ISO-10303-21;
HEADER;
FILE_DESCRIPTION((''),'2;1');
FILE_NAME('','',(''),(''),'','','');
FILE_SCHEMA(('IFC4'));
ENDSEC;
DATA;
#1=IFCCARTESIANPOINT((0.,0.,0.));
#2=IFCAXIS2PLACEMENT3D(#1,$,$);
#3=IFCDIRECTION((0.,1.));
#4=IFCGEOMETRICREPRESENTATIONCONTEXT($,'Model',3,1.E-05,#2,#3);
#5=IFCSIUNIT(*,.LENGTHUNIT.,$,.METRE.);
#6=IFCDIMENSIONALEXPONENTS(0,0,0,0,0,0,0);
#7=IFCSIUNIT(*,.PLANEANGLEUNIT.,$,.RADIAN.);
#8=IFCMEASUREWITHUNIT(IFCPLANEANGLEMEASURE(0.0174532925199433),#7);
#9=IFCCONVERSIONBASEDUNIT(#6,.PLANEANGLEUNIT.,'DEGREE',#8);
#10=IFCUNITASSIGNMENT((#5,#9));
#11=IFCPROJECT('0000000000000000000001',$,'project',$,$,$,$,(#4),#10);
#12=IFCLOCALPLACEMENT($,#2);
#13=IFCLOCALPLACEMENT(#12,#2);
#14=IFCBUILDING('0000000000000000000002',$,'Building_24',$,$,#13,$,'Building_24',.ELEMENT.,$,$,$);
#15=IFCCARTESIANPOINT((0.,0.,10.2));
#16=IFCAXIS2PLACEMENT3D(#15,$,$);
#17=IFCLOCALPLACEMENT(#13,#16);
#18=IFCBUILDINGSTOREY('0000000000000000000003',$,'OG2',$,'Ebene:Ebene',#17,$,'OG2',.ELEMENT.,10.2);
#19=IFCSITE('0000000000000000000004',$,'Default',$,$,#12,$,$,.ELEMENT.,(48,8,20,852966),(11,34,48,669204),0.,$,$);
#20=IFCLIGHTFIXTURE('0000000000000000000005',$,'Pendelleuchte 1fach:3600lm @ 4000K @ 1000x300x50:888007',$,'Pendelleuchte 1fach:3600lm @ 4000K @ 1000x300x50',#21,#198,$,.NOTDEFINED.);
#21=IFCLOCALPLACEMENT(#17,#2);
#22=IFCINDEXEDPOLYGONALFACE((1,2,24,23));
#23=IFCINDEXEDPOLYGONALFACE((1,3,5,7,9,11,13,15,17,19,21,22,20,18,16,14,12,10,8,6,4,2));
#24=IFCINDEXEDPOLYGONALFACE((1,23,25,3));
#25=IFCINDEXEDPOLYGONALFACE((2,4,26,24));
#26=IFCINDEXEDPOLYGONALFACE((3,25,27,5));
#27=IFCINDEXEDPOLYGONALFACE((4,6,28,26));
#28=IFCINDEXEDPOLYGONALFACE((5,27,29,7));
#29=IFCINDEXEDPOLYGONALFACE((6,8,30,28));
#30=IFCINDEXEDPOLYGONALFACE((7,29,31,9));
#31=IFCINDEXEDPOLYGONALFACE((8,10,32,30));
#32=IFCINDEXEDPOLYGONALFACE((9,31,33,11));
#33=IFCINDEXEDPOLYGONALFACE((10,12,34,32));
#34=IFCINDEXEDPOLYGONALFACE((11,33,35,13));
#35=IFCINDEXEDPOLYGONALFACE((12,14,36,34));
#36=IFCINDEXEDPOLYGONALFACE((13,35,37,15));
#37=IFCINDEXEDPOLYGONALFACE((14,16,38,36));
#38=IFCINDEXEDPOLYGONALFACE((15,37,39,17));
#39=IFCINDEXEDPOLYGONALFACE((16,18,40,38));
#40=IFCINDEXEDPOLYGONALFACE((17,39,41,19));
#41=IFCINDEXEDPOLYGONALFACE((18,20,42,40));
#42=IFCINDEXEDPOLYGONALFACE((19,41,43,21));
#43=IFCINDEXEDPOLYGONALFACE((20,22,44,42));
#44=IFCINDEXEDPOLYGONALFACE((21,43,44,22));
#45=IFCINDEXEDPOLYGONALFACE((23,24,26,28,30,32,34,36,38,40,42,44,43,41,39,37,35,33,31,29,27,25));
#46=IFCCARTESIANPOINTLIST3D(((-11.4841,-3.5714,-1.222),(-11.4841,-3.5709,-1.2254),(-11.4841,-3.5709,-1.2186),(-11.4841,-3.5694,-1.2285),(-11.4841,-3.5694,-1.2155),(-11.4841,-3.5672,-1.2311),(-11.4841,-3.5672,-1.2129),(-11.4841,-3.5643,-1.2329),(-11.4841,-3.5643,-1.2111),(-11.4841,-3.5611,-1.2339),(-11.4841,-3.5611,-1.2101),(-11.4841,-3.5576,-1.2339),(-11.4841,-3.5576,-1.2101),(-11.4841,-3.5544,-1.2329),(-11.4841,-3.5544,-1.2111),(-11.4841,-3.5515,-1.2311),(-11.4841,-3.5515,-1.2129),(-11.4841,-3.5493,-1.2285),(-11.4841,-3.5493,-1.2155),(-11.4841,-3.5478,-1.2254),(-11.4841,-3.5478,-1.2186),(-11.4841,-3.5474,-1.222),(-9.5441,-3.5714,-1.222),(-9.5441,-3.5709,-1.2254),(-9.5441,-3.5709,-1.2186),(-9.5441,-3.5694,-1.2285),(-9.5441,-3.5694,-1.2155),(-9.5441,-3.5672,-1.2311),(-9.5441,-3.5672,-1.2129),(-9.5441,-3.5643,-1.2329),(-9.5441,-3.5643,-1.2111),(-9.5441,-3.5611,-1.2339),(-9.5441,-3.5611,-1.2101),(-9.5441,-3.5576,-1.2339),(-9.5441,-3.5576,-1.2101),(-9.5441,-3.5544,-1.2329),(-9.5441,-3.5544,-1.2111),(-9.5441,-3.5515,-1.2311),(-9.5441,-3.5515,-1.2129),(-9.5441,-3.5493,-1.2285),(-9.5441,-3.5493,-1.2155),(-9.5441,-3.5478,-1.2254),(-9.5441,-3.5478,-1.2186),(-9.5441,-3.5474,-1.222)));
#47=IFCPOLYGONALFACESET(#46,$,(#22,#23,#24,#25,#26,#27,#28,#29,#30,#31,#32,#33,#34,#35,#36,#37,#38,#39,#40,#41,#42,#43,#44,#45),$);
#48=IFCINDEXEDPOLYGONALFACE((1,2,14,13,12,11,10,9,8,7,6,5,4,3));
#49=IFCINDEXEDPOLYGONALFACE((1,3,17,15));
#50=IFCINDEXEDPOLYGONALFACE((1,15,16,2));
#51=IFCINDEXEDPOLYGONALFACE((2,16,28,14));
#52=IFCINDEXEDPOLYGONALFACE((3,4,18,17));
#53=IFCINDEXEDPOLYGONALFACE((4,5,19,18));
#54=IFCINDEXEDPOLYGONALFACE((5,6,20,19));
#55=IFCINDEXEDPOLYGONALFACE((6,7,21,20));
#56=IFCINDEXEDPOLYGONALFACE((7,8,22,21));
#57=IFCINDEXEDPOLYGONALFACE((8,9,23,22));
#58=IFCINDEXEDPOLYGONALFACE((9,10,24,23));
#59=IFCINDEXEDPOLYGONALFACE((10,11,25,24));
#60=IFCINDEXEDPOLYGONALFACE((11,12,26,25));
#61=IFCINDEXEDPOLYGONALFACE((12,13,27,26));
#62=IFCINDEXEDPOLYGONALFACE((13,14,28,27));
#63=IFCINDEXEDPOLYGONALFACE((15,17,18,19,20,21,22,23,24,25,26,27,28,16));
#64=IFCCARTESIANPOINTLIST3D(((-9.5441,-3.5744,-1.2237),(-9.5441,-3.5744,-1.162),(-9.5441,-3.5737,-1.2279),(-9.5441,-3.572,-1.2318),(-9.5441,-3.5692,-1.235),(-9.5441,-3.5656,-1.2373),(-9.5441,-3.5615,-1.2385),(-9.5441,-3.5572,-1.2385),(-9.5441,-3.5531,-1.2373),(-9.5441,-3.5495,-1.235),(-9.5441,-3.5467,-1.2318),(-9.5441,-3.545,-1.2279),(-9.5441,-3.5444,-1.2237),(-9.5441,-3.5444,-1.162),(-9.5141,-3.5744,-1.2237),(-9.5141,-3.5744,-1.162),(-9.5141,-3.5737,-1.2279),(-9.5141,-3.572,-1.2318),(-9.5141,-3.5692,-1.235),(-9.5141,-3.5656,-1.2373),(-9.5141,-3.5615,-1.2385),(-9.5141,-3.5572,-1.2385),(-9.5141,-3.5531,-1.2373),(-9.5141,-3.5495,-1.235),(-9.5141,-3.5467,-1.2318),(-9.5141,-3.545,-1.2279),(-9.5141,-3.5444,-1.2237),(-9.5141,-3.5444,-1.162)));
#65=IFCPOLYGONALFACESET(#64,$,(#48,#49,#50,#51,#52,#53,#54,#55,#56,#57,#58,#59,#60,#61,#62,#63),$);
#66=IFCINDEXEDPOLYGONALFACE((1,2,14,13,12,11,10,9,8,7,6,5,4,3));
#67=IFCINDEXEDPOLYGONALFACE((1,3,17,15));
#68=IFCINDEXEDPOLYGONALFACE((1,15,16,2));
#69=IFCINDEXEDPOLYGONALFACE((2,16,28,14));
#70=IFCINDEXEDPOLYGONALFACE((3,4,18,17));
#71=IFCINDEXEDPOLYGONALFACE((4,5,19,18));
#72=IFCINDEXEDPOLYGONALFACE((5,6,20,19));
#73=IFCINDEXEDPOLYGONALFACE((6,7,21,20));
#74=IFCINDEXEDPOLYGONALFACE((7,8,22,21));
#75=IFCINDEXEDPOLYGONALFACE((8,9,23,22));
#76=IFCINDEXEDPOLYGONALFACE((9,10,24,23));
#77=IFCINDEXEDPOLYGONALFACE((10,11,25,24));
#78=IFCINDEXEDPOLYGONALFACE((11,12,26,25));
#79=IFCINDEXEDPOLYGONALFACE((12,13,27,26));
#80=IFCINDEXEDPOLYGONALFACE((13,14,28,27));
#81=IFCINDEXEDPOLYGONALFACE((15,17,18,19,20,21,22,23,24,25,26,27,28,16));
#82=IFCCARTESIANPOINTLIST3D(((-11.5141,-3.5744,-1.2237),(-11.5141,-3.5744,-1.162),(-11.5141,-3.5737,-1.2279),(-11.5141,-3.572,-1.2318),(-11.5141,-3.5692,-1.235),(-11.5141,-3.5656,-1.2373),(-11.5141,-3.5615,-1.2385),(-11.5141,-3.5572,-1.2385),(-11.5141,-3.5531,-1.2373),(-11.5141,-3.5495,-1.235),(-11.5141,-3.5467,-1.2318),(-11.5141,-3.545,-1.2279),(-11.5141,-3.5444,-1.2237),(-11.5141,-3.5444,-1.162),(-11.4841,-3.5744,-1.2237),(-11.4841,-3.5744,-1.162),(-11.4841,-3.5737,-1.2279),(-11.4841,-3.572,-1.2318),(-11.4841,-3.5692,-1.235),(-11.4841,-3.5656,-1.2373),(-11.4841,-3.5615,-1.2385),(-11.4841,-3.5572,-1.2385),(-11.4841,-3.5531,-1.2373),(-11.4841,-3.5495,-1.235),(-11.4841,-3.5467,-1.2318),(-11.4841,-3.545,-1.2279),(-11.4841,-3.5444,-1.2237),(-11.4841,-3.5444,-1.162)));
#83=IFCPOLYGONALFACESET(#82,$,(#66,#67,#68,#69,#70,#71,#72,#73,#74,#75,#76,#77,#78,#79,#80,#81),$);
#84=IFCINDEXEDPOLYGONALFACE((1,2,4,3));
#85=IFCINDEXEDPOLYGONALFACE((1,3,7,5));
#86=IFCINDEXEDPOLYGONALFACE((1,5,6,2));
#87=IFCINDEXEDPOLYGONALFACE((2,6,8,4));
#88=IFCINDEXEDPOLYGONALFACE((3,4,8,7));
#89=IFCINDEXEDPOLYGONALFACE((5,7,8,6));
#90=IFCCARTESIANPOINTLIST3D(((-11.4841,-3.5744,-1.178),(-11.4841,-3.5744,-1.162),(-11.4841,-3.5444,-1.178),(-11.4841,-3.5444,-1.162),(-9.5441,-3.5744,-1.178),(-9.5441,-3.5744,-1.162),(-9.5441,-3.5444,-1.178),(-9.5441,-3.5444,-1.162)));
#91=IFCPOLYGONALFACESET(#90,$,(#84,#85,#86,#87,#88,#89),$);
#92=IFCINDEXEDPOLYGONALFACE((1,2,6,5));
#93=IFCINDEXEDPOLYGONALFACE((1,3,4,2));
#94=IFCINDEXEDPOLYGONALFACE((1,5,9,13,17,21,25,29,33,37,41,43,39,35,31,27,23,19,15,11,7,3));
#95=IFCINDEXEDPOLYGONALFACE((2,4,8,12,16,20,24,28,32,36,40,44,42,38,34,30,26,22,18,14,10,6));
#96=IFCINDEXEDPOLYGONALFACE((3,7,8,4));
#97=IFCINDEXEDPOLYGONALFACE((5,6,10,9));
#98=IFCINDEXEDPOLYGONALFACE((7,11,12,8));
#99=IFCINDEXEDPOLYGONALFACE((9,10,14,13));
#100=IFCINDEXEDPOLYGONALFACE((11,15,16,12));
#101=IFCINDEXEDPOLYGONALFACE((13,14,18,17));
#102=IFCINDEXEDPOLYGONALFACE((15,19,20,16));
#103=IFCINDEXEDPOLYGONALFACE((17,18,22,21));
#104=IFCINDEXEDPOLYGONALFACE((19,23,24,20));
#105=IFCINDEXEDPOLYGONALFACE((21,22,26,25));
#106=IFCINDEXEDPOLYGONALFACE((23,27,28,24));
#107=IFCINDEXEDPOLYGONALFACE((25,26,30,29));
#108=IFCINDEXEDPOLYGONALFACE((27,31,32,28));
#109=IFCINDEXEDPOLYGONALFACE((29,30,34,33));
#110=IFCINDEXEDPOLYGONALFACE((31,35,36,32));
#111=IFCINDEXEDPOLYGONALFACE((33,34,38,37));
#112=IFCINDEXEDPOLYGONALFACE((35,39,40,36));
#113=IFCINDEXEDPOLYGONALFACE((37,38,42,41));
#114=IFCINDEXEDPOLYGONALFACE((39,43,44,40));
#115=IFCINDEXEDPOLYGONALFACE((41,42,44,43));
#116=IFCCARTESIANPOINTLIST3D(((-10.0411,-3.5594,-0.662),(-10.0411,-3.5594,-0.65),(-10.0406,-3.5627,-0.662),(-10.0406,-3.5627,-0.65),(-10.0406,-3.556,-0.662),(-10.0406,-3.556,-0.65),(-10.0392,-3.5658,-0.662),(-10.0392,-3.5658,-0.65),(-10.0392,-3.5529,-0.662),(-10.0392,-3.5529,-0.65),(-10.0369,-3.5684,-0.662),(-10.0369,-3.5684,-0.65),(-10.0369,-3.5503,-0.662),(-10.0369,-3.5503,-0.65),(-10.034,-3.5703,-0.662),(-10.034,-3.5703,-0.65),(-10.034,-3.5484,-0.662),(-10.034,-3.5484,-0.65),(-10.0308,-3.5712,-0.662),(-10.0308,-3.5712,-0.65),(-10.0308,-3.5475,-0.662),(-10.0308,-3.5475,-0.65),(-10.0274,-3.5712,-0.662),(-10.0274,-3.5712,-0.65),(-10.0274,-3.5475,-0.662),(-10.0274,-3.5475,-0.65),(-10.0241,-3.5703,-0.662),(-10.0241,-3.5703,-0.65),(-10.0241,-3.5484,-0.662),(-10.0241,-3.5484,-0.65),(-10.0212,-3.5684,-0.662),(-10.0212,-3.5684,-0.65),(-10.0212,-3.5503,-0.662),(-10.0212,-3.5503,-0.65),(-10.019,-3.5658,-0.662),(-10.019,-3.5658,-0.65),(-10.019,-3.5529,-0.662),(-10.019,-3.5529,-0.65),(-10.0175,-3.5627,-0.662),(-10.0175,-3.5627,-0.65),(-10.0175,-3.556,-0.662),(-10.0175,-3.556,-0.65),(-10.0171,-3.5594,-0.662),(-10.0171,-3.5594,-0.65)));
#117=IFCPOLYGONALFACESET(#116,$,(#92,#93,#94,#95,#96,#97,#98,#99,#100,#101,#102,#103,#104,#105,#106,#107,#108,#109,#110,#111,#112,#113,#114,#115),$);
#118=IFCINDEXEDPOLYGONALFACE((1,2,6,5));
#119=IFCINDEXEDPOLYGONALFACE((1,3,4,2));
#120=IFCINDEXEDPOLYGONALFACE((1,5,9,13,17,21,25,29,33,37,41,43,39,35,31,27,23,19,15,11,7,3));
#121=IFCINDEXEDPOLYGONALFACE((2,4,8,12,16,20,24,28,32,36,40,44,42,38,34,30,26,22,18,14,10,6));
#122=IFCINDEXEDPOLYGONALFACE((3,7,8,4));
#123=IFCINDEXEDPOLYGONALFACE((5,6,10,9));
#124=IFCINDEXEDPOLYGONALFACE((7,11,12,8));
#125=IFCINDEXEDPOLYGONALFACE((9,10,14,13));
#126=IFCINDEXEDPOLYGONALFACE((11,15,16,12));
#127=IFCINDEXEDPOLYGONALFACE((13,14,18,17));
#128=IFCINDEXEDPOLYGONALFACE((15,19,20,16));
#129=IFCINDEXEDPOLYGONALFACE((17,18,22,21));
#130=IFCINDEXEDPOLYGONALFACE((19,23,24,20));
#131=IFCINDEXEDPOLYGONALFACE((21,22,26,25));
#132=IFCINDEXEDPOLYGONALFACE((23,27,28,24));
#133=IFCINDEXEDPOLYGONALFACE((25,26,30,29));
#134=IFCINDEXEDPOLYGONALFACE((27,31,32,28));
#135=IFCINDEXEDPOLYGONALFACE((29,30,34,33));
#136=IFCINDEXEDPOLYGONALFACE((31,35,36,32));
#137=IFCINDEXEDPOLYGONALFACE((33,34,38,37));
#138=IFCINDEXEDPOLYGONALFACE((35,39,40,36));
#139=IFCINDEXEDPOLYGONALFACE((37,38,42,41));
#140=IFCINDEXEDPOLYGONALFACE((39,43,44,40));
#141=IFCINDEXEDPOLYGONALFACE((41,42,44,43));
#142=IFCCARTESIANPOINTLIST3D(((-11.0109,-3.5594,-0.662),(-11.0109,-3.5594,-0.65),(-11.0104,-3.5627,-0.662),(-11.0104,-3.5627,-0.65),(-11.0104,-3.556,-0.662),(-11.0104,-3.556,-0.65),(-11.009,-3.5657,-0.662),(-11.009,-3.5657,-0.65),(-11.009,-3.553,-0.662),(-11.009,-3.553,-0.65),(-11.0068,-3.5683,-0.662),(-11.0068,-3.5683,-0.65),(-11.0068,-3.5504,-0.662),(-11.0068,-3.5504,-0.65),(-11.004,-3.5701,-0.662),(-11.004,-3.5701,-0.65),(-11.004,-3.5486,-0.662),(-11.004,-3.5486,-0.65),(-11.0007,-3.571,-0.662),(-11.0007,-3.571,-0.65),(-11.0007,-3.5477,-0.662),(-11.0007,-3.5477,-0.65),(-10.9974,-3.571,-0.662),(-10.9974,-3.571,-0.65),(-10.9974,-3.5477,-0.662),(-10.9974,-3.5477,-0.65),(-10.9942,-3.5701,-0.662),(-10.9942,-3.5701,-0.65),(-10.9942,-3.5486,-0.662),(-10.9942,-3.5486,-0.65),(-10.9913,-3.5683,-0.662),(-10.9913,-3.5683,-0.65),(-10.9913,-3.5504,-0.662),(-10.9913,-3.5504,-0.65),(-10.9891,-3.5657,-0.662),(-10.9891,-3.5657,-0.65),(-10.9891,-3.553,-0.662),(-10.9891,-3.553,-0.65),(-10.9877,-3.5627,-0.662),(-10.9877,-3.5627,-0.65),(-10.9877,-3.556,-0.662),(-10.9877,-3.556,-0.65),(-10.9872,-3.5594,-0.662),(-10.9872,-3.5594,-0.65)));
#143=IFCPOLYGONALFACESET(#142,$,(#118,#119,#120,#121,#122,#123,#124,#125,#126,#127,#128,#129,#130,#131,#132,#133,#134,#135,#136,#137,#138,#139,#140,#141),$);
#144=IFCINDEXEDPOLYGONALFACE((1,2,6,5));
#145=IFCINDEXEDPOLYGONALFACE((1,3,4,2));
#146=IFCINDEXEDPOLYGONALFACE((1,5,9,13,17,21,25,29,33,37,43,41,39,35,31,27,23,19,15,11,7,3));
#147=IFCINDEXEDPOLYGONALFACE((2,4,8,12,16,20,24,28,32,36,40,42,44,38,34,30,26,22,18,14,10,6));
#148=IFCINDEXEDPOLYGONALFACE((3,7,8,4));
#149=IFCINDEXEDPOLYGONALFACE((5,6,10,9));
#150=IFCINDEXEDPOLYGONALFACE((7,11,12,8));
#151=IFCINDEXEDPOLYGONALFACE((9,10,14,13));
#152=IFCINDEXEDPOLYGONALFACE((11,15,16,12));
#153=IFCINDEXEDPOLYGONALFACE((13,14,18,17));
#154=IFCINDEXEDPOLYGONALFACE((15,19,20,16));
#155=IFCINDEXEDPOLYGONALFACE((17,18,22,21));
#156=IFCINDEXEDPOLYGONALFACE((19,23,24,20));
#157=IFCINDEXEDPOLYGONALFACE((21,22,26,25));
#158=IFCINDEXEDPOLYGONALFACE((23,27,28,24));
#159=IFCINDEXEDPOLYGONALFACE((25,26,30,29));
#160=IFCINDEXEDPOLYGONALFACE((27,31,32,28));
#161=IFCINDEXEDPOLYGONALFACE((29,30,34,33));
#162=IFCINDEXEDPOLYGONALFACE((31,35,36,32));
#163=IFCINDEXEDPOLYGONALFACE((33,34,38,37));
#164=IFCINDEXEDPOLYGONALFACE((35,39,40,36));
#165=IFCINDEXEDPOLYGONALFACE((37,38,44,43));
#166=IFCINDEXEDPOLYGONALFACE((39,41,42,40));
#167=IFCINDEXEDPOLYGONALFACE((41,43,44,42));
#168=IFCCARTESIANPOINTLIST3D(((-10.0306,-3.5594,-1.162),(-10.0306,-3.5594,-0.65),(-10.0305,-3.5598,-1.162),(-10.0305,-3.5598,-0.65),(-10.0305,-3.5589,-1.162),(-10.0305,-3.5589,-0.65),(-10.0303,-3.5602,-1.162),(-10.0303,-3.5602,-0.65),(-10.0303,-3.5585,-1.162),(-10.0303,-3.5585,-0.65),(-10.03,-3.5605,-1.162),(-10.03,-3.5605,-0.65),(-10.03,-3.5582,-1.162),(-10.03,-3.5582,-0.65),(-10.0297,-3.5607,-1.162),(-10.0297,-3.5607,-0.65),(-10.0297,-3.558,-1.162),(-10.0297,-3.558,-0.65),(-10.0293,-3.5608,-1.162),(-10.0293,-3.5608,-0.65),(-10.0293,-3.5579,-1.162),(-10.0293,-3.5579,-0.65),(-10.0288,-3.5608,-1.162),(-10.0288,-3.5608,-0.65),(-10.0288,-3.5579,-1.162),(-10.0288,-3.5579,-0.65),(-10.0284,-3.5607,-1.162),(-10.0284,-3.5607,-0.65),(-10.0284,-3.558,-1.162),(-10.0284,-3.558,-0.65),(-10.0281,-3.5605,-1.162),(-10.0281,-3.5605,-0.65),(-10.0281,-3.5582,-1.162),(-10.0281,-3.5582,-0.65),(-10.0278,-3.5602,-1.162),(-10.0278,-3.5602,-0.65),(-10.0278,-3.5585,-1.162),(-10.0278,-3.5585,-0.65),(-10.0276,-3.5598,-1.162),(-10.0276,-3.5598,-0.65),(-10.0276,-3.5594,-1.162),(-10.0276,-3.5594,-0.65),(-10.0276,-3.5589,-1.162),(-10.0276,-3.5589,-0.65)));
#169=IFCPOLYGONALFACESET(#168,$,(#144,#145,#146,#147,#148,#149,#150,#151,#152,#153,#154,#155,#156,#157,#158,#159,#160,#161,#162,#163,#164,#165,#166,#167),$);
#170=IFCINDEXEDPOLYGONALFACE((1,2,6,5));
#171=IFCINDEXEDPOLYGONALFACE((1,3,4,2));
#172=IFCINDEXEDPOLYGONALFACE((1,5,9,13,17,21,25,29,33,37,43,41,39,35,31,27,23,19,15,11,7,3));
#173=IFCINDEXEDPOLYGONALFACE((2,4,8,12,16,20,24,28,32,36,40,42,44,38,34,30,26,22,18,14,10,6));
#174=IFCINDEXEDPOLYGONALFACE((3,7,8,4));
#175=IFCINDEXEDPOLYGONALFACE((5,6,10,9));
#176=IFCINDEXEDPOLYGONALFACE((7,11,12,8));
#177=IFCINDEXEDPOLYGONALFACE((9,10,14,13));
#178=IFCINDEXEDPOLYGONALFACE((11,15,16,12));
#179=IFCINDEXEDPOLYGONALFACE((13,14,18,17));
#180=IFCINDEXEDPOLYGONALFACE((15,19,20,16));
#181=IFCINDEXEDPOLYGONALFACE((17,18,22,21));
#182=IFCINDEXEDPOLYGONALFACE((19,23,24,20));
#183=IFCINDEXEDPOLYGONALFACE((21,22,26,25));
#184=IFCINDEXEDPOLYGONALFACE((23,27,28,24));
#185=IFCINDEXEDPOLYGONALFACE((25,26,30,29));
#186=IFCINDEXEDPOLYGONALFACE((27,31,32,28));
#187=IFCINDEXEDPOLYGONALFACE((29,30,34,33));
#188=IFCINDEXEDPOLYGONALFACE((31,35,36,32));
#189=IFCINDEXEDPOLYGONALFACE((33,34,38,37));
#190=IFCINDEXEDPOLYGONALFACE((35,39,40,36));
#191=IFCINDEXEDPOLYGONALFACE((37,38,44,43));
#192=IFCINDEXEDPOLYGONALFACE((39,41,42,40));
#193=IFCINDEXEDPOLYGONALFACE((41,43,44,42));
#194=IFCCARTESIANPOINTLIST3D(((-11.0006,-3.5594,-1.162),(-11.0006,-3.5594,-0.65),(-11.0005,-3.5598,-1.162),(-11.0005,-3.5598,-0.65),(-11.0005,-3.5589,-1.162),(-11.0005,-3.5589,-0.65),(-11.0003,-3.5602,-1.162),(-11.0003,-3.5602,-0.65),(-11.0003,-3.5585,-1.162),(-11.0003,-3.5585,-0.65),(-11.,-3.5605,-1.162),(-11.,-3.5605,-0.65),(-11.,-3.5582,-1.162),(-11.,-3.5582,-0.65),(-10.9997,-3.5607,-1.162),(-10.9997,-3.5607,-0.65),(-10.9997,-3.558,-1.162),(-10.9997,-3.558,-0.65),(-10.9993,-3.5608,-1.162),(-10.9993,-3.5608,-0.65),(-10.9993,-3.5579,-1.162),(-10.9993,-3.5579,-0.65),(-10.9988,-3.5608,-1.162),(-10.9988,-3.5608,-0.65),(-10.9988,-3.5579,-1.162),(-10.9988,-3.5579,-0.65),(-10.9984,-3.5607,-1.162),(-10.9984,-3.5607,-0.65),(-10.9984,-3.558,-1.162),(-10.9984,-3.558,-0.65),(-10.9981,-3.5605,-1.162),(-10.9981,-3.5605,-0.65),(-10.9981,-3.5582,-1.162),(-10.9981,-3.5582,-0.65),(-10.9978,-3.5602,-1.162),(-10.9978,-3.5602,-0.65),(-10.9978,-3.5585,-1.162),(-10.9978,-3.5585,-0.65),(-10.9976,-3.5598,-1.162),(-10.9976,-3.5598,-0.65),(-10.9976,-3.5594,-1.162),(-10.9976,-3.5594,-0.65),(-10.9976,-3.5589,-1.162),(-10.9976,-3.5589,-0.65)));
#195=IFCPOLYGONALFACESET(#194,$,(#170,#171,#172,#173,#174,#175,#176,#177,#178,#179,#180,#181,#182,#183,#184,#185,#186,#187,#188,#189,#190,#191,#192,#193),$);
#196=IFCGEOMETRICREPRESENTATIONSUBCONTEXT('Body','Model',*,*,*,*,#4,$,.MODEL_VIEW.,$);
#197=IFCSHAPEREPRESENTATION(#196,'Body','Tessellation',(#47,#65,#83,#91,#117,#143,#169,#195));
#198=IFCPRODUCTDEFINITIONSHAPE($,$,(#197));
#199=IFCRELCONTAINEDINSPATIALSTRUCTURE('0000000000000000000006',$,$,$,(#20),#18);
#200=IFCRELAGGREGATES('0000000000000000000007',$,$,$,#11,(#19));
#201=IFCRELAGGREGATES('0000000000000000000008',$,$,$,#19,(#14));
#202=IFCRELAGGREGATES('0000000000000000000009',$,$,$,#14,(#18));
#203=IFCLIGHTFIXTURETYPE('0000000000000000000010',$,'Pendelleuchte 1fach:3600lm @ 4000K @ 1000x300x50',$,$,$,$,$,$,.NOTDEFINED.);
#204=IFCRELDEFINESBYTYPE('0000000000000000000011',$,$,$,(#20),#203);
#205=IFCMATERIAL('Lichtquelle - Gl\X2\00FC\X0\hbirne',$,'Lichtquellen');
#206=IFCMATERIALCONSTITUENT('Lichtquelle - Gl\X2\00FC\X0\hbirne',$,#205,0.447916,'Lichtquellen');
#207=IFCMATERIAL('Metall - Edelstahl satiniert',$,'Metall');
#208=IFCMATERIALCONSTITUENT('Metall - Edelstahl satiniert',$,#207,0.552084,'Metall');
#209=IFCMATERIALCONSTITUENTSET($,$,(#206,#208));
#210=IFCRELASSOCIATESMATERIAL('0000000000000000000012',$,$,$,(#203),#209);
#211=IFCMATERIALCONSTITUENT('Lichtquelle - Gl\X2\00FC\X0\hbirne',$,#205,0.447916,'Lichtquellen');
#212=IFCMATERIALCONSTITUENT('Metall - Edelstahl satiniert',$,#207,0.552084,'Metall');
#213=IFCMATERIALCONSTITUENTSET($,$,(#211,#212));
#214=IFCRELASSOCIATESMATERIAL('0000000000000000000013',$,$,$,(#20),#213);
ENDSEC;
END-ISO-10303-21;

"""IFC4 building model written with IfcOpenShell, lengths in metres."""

from ifc_helpers import new_model, entity, si_unit, converted_unit, direction, frame, origin, place, context, subcontext, project, spatial, line, arc, indexed_curve, outline, extrude, source, transform, mapped, material, constituent, constituent_set, type_object, type_shapes, element, save


model = new_model("IFC4")

# Units and contexts
model_context = context("Model", 3, precision=1e-05, world=origin(), true_north=direction((0.0, 1.0)))
body_context = subcontext(model_context, "Body", "Model", "MODEL_VIEW")
ifc_project = project(units=[si_unit("LENGTHUNIT", "METRE"), converted_unit("PLANEANGLEUNIT", "DEGREE", entity("IfcPlaneAngleMeasure", 0.0174532925199433), si_unit("PLANEANGLEUNIT", "RADIAN"), dimensions=[0, 0, 0, 0, 0, 0, 0])], contexts=[model_context])

# Site, building, storey
site_placement = place(None, origin())
site = spatial("IfcSite", under=ifc_project, at=site_placement, Name="Default", CompositionType="ELEMENT", RefLatitude=(48, 8, 20, 852966), RefLongitude=(11, 34, 48, 669204), RefElevation=0.0)
building_placement = place(site_placement, origin())
building = spatial("IfcBuilding", under=site, at=building_placement, Name="Building_24", LongName="Building_24", CompositionType="ELEMENT")
storey_placement = place(building_placement, frame((0.0, 0.0, 10.2)))
storey = spatial("IfcBuildingStorey", under=building, at=storey_placement, Name="OG2", ObjectType="Ebene:Ebene", LongName="OG2", CompositionType="ELEMENT", Elevation=10.2)

# Light fixture
ifc_material_1 = material(Name="Lichtquelle - Glühbirne", Category="Lichtquellen")
ifc_material_2 = material(Name="Metall - Edelstahl satiniert", Category="Metall")
ifc_constituent_1 = constituent(ifc_material_1, Name="Lichtquelle - Glühbirne", Category="Lichtquellen", fraction=0.447916)
ifc_constituent_2 = constituent(ifc_material_2, Name="Metall - Edelstahl satiniert", Category="Metall", fraction=0.552084)
ifc_constituent_set_1 = constituent_set(constituents=[ifc_constituent_1, ifc_constituent_2])
light_fixture_type_1 = type_object("IfcLightFixtureType", Name="Pendelleuchte 1fach:3600lm @ 4000K @ 1000x300x50", PredefinedType="NOTDEFINED", material=ifc_constituent_set_1)
shared_shape_1 = source(origin(), body_context, "Body", "SweptSolid", [
    extrude(outline(indexed_curve([(-0.012, 0.0), (0.0, -0.012), (0.012, 0.0), (0.0, 0.012)], segments=[arc(1, 2, 3), arc(3, 4, 1)], self_intersect=False)), frame((-0.97, 0.0, -0.572), z_axis=(1.0, 0.0, 0.0), x_axis=(0.0, 1.0, 0.0)), (0.0, 0.0, 1.0), 1.94),
    extrude(outline(indexed_curve([(-0.0308, -0.015), (0.0308, -0.015), (0.0308, 0.015), (-0.0308, 0.015), (-0.0458, 0.0)], segments=[line(1, 2, 3, 4), arc(4, 5, 1)], self_intersect=False)), frame((0.97, 0.0, -0.5428), z_axis=(1.0, 0.0, 0.0), x_axis=(0.0, 0.0, 1.0)), (0.0, 0.0, 1.0), 0.03),
    extrude(outline(indexed_curve([(-0.0308, -0.015), (0.0308, -0.015), (0.0308, 0.015), (-0.0308, 0.015), (-0.0458, 0.0)], segments=[line(1, 2, 3, 4), arc(4, 5, 1)], self_intersect=False)), frame((-1.0, 0.0, -0.5428), z_axis=(1.0, 0.0, 0.0), x_axis=(0.0, 0.0, 1.0)), (0.0, 0.0, 1.0), 0.03),
    extrude(outline(indexed_curve([(-0.97, -0.015), (0.97, -0.015), (0.97, 0.015), (-0.97, 0.015), (-0.97, -0.015)], self_intersect=False)), frame((0.0, 0.0, -0.528), z_axis=(0.0, 0.0, 1.0), x_axis=(-1.0, 0.0, 0.0)), (0.0, 0.0, 1.0), 0.016),
    extrude(outline(indexed_curve([(-0.012, 0.0), (0.0, -0.012), (0.012, 0.0), (0.0, 0.012)], segments=[arc(1, 2, 3), arc(3, 4, 1)], self_intersect=False)), frame((0.485, 0.0, -0.012)), (0.0, 0.0, 1.0), 0.012),
    extrude(outline(indexed_curve([(-0.0118, 0.0), (0.0, -0.0118), (0.0118, 0.0), (0.0, 0.0118)], segments=[arc(1, 2, 3), arc(3, 4, 1)], self_intersect=False)), frame((-0.485, 0.0, -0.012)), (0.0, 0.0, 1.0), 0.012),
    extrude(outline(indexed_curve([(-0.0015, 0.0), (0.0, -0.0015), (0.0015, 0.0), (0.0, 0.0015)], segments=[arc(1, 2, 3), arc(3, 4, 1)], self_intersect=False)), frame((0.485, 0.0, -0.512)), (0.0, 0.0, 1.0), 0.512),
    extrude(outline(indexed_curve([(-0.0015, 0.0), (0.0, -0.0015), (0.0015, 0.0), (0.0, 0.0015)], segments=[arc(1, 2, 3), arc(3, 4, 1)], self_intersect=False)), frame((-0.485, 0.0, -0.512)), (0.0, 0.0, 1.0), 0.512),
])
type_shapes(light_fixture_type_1, [shared_shape_1])
ifc_constituent_3 = constituent(ifc_material_1, Name="Lichtquelle - Glühbirne", Category="Lichtquellen", fraction=0.447916)
ifc_constituent_4 = constituent(ifc_material_2, Name="Metall - Edelstahl satiniert", Category="Metall", fraction=0.552084)
ifc_constituent_set_2 = constituent_set(constituents=[ifc_constituent_3, ifc_constituent_4])
light_fixture_1_placement = place(storey_placement, frame((-10.5141, -3.5594, -0.65)))
element("IfcLightFixture", 1, at=light_fixture_1_placement, inside=storey, type_object=light_fixture_type_1, material=ifc_constituent_set_2, Name="Pendelleuchte 1fach:3600lm @ 4000K @ 1000x300x50:888007", ObjectType="Pendelleuchte 1fach:3600lm @ 4000K @ 1000x300x50", PredefinedType="NOTDEFINED", context=body_context, shape_type="MappedRepresentation", body=[
    mapped(shared_shape_1, transform((0.0, 0.0, 0.0), scale=1.0)),
])

save(model, "model.ifc")
